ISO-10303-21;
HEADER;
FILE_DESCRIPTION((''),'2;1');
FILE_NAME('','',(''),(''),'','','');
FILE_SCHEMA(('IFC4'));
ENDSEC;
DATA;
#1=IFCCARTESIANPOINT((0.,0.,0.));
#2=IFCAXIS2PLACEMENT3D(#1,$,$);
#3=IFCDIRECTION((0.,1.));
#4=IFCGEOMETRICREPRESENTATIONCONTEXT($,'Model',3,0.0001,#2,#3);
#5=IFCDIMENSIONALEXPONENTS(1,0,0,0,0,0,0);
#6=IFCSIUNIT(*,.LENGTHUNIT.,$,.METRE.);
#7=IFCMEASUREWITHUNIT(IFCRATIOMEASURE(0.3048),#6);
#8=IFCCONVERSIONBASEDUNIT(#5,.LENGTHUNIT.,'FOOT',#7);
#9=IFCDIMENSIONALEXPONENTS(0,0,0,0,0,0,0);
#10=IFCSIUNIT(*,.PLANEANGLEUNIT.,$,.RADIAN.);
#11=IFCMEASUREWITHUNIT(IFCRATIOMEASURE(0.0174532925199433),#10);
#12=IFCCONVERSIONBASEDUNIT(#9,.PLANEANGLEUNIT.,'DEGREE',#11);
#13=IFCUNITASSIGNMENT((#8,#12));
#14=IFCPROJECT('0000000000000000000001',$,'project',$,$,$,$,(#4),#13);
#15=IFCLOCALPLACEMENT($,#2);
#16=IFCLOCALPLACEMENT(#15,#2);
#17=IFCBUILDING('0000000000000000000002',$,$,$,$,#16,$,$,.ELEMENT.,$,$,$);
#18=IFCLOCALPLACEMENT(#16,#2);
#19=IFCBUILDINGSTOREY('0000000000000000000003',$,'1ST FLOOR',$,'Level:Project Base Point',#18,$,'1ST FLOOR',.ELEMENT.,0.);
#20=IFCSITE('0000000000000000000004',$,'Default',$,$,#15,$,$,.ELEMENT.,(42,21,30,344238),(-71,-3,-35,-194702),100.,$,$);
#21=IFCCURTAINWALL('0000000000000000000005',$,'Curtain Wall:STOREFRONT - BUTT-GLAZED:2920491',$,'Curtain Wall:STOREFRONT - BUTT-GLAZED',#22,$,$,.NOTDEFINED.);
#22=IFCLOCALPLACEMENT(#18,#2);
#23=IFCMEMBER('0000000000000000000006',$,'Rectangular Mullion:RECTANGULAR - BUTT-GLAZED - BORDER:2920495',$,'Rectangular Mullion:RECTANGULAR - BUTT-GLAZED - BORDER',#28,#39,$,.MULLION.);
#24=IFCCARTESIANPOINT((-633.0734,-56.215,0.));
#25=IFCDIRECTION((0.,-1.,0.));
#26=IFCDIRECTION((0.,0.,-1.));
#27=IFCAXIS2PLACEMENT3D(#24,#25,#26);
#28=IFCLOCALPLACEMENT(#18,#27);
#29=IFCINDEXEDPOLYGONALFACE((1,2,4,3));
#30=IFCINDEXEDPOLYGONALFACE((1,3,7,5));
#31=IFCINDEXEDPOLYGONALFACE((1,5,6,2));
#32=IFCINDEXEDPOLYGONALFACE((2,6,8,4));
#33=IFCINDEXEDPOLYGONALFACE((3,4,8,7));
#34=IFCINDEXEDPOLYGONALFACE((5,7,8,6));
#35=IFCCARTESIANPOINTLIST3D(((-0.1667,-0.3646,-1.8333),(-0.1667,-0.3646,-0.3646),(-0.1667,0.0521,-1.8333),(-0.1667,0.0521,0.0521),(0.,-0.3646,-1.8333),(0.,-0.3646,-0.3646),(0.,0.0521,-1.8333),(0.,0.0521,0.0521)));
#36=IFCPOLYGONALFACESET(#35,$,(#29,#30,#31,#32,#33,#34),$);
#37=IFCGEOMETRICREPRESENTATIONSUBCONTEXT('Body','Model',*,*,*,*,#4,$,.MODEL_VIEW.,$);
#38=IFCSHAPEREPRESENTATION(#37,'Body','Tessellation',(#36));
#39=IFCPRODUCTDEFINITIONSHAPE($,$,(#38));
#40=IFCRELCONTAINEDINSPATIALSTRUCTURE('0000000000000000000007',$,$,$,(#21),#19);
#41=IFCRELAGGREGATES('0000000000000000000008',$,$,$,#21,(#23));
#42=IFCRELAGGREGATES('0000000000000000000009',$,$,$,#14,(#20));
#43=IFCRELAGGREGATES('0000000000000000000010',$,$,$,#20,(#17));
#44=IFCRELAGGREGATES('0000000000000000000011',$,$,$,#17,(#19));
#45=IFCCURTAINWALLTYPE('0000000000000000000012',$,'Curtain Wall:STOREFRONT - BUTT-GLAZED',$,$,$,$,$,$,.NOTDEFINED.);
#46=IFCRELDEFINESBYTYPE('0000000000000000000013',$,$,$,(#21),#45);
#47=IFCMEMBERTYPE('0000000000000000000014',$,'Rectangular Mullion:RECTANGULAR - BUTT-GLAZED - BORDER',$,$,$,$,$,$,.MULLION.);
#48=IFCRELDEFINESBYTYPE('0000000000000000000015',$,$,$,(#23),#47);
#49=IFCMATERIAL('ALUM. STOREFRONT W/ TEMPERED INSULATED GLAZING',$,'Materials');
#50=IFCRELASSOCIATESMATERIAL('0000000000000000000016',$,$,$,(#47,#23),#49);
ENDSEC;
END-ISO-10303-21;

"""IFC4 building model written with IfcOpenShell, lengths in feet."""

from ifc_helpers import new_model, entity, si_unit, converted_unit, direction, frame, frame_2d, origin, place, context, subcontext, project, spatial, rectangle, extrude, clip, halfspace, source, transform, mapped, material, material_profile, profile_set, profile_usage, type_object, type_shapes, element, aggregate, save


model = new_model("IFC4")

# Units and contexts
model_context = context("Model", 3, precision=0.0001, world=origin(), true_north=direction((0.0, 1.0)))
body_context = subcontext(model_context, "Body", "Model", "MODEL_VIEW")
ifc_project = project(units=[converted_unit("LENGTHUNIT", "FOOT", entity("IfcRatioMeasure", 0.3048), si_unit("LENGTHUNIT", "METRE"), dimensions=[1, 0, 0, 0, 0, 0, 0]), converted_unit("PLANEANGLEUNIT", "DEGREE", entity("IfcRatioMeasure", 0.0174532925199433), si_unit("PLANEANGLEUNIT", "RADIAN"), dimensions=[0, 0, 0, 0, 0, 0, 0])], contexts=[model_context])

# Site, building, storey
site_placement = place(None, origin())
site = spatial("IfcSite", under=ifc_project, at=site_placement, Name="Default", CompositionType="ELEMENT", RefLatitude=(42, 21, 30, 344238), RefLongitude=(-71, -3, -35, -194702), RefElevation=100.0)
building_placement = place(site_placement, origin())
building = spatial("IfcBuilding", under=site, at=building_placement, CompositionType="ELEMENT")
storey_placement = place(building_placement, origin())
storey = spatial("IfcBuildingStorey", under=building, at=storey_placement, Name="1ST FLOOR", ObjectType="Level:Project Base Point", LongName="1ST FLOOR", CompositionType="ELEMENT", Elevation=0.0)

# Shared definitions
ifc_material_1 = material(Name="ALUM. STOREFRONT W/ TEMPERED INSULATED GLAZING", Category="Materials")

# Curtain wall, member
curtain_wall_type_1 = type_object("IfcCurtainWallType", Name="Curtain Wall:STOREFRONT - BUTT-GLAZED", PredefinedType="NOTDEFINED")
curtain_wall_1_placement = place(storey_placement, origin())
curtain_wall_1 = element("IfcCurtainWall", 1, at=curtain_wall_1_placement, inside=storey, type_object=curtain_wall_type_1, Name="Curtain Wall:STOREFRONT - BUTT-GLAZED:2920491", ObjectType="Curtain Wall:STOREFRONT - BUTT-GLAZED", PredefinedType="NOTDEFINED")
ifc_material_profile_1 = material_profile(ifc_material_1, rectangle(XDim=0.4167, YDim=0.1667, at=frame_2d((0.0, 0.0), x_axis=(1.0, 0.0))), Name="RECTANGULAR - BUTT-GLAZED - BORDER")
ifc_profile_set_1 = profile_set([ifc_material_profile_1], Name="RECTANGULAR - BUTT-GLAZED - BORDER")
ifc_profile_usage_1 = profile_usage(ifc_profile_set_1)
member_type_1 = type_object("IfcMemberType", Name="Rectangular Mullion:RECTANGULAR - BUTT-GLAZED - BORDER", PredefinedType="MULLION", material=ifc_profile_set_1)
shared_shape_1 = source(origin(), body_context, "Body", "Clipping", [
    clip(extrude(rectangle(XDim=0.4167, YDim=0.1667, at=frame_2d((0.0, 0.0), x_axis=(1.0, 0.0))), frame((-0.0833, -0.1562, -1.8333), z_axis=(0.0, 0.0, 1.0), x_axis=(0.0, -1.0, 0.0)), (0.0, 0.0, 1.0), 1.8854), halfspace(frame((1.0, 0.0, 0.0), z_axis=(0.0, -0.707107, 0.707107), x_axis=(0.0, -0.707107, -0.707107)), False)),
])
type_shapes(member_type_1, [shared_shape_1])
member_1_placement = place(storey_placement, frame((-633.0734, -56.215, 0.0), z_axis=(0.0, -1.0, 0.0), x_axis=(0.0, 0.0, -1.0)))
member_1 = element("IfcMember", 2, at=member_1_placement, type_object=member_type_1, material=ifc_profile_usage_1, Name="Rectangular Mullion:RECTANGULAR - BUTT-GLAZED - BORDER:2920495", ObjectType="Rectangular Mullion:RECTANGULAR - BUTT-GLAZED - BORDER", PredefinedType="MULLION", context=body_context, shape_type="MappedRepresentation", body=[
    mapped(shared_shape_1, transform((0.0, 0.0, 0.0), scale=1.0)),
])

aggregate(curtain_wall_1, [member_1])

save(model, "model.ifc")
